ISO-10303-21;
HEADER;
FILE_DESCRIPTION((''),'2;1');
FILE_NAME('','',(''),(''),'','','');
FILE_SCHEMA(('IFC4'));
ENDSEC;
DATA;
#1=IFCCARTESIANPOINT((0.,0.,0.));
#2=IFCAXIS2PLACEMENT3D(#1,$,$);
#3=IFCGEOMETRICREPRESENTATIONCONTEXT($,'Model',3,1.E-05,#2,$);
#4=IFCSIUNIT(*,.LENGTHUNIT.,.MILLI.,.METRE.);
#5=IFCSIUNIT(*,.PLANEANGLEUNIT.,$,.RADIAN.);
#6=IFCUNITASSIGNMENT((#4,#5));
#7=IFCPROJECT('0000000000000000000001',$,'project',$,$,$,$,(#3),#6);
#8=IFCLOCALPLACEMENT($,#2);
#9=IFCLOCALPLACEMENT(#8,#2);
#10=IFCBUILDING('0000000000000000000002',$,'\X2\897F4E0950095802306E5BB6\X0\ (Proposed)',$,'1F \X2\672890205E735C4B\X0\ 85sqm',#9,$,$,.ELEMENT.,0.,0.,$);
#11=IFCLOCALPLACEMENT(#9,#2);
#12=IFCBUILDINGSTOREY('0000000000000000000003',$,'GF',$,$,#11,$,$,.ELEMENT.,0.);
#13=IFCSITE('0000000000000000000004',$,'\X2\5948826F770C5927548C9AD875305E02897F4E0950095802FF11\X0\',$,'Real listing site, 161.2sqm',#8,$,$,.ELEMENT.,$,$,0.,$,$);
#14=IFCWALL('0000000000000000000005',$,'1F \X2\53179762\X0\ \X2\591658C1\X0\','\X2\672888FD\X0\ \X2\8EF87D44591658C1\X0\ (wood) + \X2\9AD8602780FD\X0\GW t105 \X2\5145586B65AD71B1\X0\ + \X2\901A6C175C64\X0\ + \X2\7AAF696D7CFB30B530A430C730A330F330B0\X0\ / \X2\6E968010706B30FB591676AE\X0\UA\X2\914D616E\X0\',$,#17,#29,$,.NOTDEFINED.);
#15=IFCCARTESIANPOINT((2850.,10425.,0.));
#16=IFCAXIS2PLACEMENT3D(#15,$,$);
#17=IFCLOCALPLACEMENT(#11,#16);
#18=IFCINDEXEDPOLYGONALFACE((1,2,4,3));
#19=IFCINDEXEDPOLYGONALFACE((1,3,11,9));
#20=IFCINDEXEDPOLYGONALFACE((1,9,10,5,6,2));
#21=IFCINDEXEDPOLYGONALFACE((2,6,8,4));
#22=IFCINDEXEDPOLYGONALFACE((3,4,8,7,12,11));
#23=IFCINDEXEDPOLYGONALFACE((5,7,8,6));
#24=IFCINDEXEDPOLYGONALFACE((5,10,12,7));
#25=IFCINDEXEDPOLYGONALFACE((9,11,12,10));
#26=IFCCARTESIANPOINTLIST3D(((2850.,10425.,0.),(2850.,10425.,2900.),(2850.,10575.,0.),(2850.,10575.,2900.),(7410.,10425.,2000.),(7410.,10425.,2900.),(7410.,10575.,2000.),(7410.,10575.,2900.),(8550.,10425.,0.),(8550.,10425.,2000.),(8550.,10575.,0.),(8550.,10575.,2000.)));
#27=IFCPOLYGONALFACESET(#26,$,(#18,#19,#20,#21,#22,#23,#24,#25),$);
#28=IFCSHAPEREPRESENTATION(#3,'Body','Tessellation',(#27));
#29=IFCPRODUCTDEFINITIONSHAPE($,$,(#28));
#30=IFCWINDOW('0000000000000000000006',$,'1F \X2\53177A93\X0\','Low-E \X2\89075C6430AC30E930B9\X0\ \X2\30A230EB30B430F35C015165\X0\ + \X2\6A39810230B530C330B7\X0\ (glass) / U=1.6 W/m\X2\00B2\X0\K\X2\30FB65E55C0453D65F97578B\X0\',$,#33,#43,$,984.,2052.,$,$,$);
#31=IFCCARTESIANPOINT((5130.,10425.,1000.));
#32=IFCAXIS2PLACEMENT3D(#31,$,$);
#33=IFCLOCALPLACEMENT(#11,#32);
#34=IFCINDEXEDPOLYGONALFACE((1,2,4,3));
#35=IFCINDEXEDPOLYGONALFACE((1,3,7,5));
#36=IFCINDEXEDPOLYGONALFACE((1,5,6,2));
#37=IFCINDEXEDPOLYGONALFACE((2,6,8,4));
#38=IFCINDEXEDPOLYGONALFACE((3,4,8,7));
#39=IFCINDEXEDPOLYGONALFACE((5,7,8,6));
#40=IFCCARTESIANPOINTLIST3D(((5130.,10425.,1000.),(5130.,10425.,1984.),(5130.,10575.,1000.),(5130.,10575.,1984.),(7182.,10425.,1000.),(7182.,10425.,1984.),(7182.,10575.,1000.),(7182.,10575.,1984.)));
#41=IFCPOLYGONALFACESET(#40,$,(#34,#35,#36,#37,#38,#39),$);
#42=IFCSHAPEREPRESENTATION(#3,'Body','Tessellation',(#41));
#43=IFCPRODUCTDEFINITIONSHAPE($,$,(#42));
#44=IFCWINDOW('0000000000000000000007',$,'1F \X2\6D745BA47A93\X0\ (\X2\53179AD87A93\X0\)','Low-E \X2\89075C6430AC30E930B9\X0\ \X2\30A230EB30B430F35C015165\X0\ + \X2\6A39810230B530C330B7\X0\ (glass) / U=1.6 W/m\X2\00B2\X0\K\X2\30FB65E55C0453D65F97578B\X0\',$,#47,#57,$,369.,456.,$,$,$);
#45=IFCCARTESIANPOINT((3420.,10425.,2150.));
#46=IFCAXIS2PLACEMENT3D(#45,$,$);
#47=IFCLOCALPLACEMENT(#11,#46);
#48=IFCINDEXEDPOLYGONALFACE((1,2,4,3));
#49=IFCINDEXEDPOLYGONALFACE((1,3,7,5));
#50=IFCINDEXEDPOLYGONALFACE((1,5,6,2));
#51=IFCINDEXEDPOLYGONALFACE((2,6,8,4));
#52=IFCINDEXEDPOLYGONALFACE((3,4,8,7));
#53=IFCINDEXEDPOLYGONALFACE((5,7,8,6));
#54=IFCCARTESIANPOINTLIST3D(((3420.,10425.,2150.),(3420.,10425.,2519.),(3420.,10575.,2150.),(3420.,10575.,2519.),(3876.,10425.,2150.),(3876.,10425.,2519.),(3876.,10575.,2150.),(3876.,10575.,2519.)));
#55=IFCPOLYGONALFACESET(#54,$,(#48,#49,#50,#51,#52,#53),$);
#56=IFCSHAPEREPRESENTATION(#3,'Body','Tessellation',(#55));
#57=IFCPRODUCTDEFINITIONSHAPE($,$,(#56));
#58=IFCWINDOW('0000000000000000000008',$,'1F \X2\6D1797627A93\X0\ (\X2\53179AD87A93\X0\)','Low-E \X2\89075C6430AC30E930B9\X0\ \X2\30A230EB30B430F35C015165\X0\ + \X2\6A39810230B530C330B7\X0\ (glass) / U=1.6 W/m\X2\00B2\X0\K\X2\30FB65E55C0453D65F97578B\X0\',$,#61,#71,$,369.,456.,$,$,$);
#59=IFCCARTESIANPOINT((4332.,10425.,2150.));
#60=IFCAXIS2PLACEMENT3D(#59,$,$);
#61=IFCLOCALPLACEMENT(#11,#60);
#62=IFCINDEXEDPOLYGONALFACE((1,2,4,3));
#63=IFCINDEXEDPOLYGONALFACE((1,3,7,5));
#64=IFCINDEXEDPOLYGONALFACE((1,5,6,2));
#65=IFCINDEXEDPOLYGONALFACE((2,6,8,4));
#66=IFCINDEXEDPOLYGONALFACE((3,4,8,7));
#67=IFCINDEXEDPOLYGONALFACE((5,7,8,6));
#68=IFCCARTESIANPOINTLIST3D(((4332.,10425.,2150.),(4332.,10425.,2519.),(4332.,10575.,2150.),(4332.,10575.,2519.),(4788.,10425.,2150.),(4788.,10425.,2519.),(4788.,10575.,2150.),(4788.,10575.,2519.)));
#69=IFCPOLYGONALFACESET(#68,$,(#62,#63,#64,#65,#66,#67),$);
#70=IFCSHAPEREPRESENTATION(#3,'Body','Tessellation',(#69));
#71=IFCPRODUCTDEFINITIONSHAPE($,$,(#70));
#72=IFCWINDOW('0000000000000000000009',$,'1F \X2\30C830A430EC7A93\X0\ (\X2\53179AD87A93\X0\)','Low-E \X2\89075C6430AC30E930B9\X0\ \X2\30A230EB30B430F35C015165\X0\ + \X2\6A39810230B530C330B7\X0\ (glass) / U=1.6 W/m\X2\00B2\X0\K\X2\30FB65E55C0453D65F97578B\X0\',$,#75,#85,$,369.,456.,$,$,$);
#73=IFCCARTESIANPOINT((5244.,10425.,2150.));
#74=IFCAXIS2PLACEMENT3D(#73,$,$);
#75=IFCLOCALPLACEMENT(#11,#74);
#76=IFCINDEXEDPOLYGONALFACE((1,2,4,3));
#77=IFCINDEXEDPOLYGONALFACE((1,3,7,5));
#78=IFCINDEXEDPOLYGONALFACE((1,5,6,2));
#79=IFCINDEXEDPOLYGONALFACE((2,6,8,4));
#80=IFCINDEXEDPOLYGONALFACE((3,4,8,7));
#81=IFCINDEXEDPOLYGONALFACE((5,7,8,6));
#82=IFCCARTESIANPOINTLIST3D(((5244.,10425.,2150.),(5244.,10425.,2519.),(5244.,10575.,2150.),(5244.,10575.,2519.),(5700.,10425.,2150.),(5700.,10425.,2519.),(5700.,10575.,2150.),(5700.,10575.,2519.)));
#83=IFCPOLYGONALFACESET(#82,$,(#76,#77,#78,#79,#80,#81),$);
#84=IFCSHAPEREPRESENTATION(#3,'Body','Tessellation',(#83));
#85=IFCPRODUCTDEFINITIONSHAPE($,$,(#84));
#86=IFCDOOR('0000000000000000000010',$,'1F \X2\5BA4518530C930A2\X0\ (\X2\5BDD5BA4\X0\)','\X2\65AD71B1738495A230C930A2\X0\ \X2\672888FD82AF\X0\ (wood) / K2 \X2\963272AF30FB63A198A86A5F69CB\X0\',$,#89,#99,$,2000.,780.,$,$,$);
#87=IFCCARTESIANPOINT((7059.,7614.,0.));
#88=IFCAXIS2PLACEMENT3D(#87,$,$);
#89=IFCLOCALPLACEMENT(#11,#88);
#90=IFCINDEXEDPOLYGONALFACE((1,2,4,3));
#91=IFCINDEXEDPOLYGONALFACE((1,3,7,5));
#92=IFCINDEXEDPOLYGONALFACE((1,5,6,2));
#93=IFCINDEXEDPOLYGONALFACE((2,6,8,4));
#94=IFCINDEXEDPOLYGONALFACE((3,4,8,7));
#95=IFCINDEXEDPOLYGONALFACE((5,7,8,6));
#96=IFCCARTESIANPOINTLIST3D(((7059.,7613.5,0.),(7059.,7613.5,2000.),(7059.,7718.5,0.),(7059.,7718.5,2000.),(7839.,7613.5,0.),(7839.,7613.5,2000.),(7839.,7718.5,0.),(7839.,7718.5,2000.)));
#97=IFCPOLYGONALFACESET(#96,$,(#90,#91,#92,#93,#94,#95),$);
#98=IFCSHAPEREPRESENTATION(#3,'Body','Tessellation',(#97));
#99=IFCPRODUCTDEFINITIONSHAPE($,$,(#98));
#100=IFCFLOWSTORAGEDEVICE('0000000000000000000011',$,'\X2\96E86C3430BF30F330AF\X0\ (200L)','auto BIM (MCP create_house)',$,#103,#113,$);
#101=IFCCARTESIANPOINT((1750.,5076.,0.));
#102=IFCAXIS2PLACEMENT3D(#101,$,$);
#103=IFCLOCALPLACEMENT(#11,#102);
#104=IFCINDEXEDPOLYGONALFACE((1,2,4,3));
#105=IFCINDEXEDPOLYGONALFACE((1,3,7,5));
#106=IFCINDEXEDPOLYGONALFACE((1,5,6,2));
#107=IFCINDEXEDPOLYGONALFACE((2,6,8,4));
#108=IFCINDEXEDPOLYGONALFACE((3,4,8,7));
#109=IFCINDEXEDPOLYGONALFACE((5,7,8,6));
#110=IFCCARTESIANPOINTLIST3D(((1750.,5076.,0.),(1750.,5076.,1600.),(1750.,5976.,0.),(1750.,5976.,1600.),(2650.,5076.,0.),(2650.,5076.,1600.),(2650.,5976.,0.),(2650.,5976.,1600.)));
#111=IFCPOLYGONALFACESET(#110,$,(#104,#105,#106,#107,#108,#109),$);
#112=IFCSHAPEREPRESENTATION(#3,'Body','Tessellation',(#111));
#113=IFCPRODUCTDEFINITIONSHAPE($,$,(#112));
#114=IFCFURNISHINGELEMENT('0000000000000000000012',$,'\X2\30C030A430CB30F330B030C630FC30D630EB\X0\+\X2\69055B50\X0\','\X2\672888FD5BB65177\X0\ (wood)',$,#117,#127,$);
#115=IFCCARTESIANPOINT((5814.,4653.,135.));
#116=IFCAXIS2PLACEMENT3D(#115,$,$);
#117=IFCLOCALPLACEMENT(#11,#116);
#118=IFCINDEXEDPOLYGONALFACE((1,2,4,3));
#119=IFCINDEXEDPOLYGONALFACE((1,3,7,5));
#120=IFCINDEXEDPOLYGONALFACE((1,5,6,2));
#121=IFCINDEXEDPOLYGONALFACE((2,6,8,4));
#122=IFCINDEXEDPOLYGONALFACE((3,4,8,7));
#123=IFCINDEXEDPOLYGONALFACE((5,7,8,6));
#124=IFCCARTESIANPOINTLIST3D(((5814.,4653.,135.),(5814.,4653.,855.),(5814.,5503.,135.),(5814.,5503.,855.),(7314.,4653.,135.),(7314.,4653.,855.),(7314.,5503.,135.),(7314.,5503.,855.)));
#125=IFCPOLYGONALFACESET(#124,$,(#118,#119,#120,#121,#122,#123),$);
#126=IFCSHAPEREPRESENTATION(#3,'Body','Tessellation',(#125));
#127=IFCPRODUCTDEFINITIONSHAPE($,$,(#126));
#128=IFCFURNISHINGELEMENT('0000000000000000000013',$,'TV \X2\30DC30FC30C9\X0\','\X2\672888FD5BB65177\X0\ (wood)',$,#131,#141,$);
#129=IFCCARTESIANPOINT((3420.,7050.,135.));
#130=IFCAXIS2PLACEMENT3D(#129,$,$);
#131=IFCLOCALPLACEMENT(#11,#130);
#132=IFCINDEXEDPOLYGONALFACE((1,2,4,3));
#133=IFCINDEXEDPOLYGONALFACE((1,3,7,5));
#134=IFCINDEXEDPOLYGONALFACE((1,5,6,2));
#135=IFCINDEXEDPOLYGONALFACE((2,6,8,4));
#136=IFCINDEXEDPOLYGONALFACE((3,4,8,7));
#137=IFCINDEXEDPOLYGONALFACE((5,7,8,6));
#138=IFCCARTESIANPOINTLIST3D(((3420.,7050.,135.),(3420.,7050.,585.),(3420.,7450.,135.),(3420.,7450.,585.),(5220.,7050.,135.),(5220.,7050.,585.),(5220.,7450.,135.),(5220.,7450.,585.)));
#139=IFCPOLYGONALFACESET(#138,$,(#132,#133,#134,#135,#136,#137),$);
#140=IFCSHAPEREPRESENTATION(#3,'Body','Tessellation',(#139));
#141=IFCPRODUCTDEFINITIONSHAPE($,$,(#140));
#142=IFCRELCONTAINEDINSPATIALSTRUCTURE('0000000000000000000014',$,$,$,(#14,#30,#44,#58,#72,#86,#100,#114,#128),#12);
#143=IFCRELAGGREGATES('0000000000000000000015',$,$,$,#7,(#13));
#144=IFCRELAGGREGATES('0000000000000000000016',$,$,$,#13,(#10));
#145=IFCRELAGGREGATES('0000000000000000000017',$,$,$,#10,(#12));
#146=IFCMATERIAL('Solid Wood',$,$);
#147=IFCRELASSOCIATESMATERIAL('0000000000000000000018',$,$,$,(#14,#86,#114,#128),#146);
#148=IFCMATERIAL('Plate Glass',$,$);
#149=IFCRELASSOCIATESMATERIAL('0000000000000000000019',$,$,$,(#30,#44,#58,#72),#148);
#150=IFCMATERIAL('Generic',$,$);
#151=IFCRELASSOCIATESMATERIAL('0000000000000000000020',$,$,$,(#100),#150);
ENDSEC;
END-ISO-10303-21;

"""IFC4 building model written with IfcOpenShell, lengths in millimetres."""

from ifc_helpers import new_model, si_unit, frame, frame_2d, origin, place, context, project, spatial, rectangle, extrude, material, element, fill, save


model = new_model("IFC4")

# Units and contexts
model_context = context("Model", 3, precision=1e-05, world=origin())
ifc_project = project(units=[si_unit("LENGTHUNIT", "METRE", prefix="MILLI"), si_unit("PLANEANGLEUNIT", "RADIAN")], contexts=[model_context])

# Site, building, storey
site_placement = place(None, origin())
site = spatial("IfcSite", under=ifc_project, at=site_placement, Name="奈良県大和高田市西三倉堂１", ObjectType="Real listing site, 161.2sqm", CompositionType="ELEMENT", RefElevation=0.0)
building_placement = place(site_placement, origin())
building = spatial("IfcBuilding", under=site, at=building_placement, Name="西三倉堂の家 (Proposed)", ObjectType="1F 木造平屋 85sqm", CompositionType="ELEMENT", ElevationOfRefHeight=0.0, ElevationOfTerrain=0.0)
storey_placement = place(building_placement, origin())
storey = spatial("IfcBuildingStorey", under=building, at=storey_placement, Name="GF", CompositionType="ELEMENT", Elevation=0.0)

# Wall, openings, windows
ifc_material_1 = material(Name="Solid Wood")
wall_1_placement = place(storey_placement, frame((2850.0, 10425.0, 0.0)))
wall_1 = element("IfcWall", 1, at=wall_1_placement, inside=storey, material=ifc_material_1, Name="1F 北面 外壁", Description="木製 軸組外壁 (wood) + 高性能GW t105 充填断熱 + 通気層 + 窯業系サイディング / 準耐火・外皮UA配慮", PredefinedType="NOTDEFINED", context=model_context, shape_type="SweptSolid", body=[
    extrude(rectangle(XDim=5700.0, YDim=150.0, at=frame_2d((2850.0, 75.0))), frame((2850.0, 10425.0, 0.0)), (0.0, 0.0, 1.0), 2900.0),
])
opening_1_placement = place(storey_placement, frame((5130.0, 10425.0, 1000.0)))
opening_1 = element("IfcOpeningElement", 2, at=opening_1_placement, cuts=wall_1, PredefinedType="NOTDEFINED", context=model_context, shape_type="SweptSolid", body=[
    extrude(rectangle(XDim=2052.0, YDim=150.0, at=frame_2d((1026.0, 75.0))), frame((5130.0, 10425.0, 1000.0)), (0.0, 0.0, 1.0), 984.0),
])
opening_2_placement = place(storey_placement, frame((3420.0, 10425.0, 2150.0)))
opening_2 = element("IfcOpeningElement", 3, at=opening_2_placement, cuts=wall_1, PredefinedType="NOTDEFINED", context=model_context, shape_type="SweptSolid", body=[
    extrude(rectangle(XDim=456.0, YDim=150.0, at=frame_2d((228.0, 75.0))), frame((3420.0, 10425.0, 2150.0)), (0.0, 0.0, 1.0), 369.0),
])
opening_3_placement = place(storey_placement, frame((4332.0, 10425.0, 2150.0)))
opening_3 = element("IfcOpeningElement", 4, at=opening_3_placement, cuts=wall_1, PredefinedType="NOTDEFINED", context=model_context, shape_type="SweptSolid", body=[
    extrude(rectangle(XDim=456.0, YDim=150.0, at=frame_2d((228.0, 75.0))), frame((4332.0, 10425.0, 2150.0)), (0.0, 0.0, 1.0), 369.0),
])
opening_4_placement = place(storey_placement, frame((5244.0, 10425.0, 2150.0)))
opening_4 = element("IfcOpeningElement", 5, at=opening_4_placement, cuts=wall_1, PredefinedType="NOTDEFINED", context=model_context, shape_type="SweptSolid", body=[
    extrude(rectangle(XDim=456.0, YDim=150.0, at=frame_2d((228.0, 75.0))), frame((5244.0, 10425.0, 2150.0)), (0.0, 0.0, 1.0), 369.0),
])
ifc_material_2 = material(Name="Plate Glass")
window_1_placement = place(storey_placement, frame((5130.0, 10425.0, 1000.0)))
window_1 = element("IfcWindow", 6, at=window_1_placement, inside=storey, material=ifc_material_2, Name="1F 北窓", Description="Low-E 複層ガラス アルゴン封入 + 樹脂サッシ (glass) / U=1.6 W/m²K・日射取得型", OverallHeight=984.0, OverallWidth=2052.0, context=model_context, shape_type="SweptSolid", body=[
    extrude(rectangle(XDim=2052.0, YDim=150.0, at=frame_2d((1026.0, 75.0))), frame((5130.0, 10425.0, 1000.0)), (0.0, 0.0, 1.0), 984.0),
])
fill(opening_1, window_1)
window_2_placement = place(storey_placement, frame((3420.0, 10425.0, 2150.0)))
window_2 = element("IfcWindow", 7, at=window_2_placement, inside=storey, material=ifc_material_2, Name="1F 浴室窓 (北高窓)", Description="Low-E 複層ガラス アルゴン封入 + 樹脂サッシ (glass) / U=1.6 W/m²K・日射取得型", OverallHeight=369.0, OverallWidth=456.0, context=model_context, shape_type="SweptSolid", body=[
    extrude(rectangle(XDim=456.0, YDim=150.0, at=frame_2d((228.0, 75.0))), frame((3420.0, 10425.0, 2150.0)), (0.0, 0.0, 1.0), 369.0),
])
fill(opening_2, window_2)
window_3_placement = place(storey_placement, frame((4332.0, 10425.0, 2150.0)))
window_3 = element("IfcWindow", 8, at=window_3_placement, inside=storey, material=ifc_material_2, Name="1F 洗面窓 (北高窓)", Description="Low-E 複層ガラス アルゴン封入 + 樹脂サッシ (glass) / U=1.6 W/m²K・日射取得型", OverallHeight=369.0, OverallWidth=456.0, context=model_context, shape_type="SweptSolid", body=[
    extrude(rectangle(XDim=456.0, YDim=150.0, at=frame_2d((228.0, 75.0))), frame((4332.0, 10425.0, 2150.0)), (0.0, 0.0, 1.0), 369.0),
])
fill(opening_3, window_3)
window_4_placement = place(storey_placement, frame((5244.0, 10425.0, 2150.0)))
window_4 = element("IfcWindow", 9, at=window_4_placement, inside=storey, material=ifc_material_2, Name="1F トイレ窓 (北高窓)", Description="Low-E 複層ガラス アルゴン封入 + 樹脂サッシ (glass) / U=1.6 W/m²K・日射取得型", OverallHeight=369.0, OverallWidth=456.0, context=model_context, shape_type="SweptSolid", body=[
    extrude(rectangle(XDim=456.0, YDim=150.0, at=frame_2d((228.0, 75.0))), frame((5244.0, 10425.0, 2150.0)), (0.0, 0.0, 1.0), 369.0),
])
fill(opening_4, window_4)

# Door
door_1_placement = place(storey_placement, frame((7059.0, 7614.0, 0.0)))
element("IfcDoor", 10, at=door_1_placement, inside=storey, material=ifc_material_1, Name="1F 室内ドア (寝室)", Description="断熱玄関ドア 木製芯 (wood) / K2 防犯・採風機構", OverallHeight=2000.0, OverallWidth=780.0, context=model_context, shape_type="SweptSolid", body=[
    extrude(rectangle(XDim=780.0, YDim=105.0, at=frame_2d((390.0, 52.0))), frame((7059.0, 7614.0, 0.0)), (0.0, 0.0, 1.0), 2000.0),
])

# Flow storage device
ifc_material_3 = material(Name="Generic")
flow_storage_device_placement = place(storey_placement, frame((1750.0, 5076.0, 0.0)))
element("IfcFlowStorageDevice", 11, at=flow_storage_device_placement, inside=storey, material=ifc_material_3, Name="雨水タンク (200L)", Description="auto BIM (MCP create_house)", context=model_context, shape_type="SweptSolid", body=[
    extrude(rectangle(XDim=900.0, YDim=900.0, at=frame_2d((450.0, 450.0))), frame((1750.0, 5076.0, 0.0)), (0.0, 0.0, 1.0), 1600.0),
])

# Furnishing elements
furnishing_1_placement = place(storey_placement, frame((5814.0, 4653.0, 135.0)))
element("IfcFurnishingElement", 12, at=furnishing_1_placement, inside=storey, material=ifc_material_1, Name="ダイニングテーブル+椅子", Description="木製家具 (wood)", context=model_context, shape_type="SweptSolid", body=[
    extrude(rectangle(XDim=1500.0, YDim=850.0, at=frame_2d((750.0, 425.0))), frame((5814.0, 4653.0, 135.0)), (0.0, 0.0, 1.0), 720.0),
])
furnishing_2_placement = place(storey_placement, frame((3420.0, 7050.0, 135.0)))
element("IfcFurnishingElement", 13, at=furnishing_2_placement, inside=storey, material=ifc_material_1, Name="TV ボード", Description="木製家具 (wood)", context=model_context, shape_type="SweptSolid", body=[
    extrude(rectangle(XDim=1800.0, YDim=400.0, at=frame_2d((900.0, 200.0))), frame((3420.0, 7050.0, 135.0)), (0.0, 0.0, 1.0), 450.0),
])

save(model, "model.ifc")
